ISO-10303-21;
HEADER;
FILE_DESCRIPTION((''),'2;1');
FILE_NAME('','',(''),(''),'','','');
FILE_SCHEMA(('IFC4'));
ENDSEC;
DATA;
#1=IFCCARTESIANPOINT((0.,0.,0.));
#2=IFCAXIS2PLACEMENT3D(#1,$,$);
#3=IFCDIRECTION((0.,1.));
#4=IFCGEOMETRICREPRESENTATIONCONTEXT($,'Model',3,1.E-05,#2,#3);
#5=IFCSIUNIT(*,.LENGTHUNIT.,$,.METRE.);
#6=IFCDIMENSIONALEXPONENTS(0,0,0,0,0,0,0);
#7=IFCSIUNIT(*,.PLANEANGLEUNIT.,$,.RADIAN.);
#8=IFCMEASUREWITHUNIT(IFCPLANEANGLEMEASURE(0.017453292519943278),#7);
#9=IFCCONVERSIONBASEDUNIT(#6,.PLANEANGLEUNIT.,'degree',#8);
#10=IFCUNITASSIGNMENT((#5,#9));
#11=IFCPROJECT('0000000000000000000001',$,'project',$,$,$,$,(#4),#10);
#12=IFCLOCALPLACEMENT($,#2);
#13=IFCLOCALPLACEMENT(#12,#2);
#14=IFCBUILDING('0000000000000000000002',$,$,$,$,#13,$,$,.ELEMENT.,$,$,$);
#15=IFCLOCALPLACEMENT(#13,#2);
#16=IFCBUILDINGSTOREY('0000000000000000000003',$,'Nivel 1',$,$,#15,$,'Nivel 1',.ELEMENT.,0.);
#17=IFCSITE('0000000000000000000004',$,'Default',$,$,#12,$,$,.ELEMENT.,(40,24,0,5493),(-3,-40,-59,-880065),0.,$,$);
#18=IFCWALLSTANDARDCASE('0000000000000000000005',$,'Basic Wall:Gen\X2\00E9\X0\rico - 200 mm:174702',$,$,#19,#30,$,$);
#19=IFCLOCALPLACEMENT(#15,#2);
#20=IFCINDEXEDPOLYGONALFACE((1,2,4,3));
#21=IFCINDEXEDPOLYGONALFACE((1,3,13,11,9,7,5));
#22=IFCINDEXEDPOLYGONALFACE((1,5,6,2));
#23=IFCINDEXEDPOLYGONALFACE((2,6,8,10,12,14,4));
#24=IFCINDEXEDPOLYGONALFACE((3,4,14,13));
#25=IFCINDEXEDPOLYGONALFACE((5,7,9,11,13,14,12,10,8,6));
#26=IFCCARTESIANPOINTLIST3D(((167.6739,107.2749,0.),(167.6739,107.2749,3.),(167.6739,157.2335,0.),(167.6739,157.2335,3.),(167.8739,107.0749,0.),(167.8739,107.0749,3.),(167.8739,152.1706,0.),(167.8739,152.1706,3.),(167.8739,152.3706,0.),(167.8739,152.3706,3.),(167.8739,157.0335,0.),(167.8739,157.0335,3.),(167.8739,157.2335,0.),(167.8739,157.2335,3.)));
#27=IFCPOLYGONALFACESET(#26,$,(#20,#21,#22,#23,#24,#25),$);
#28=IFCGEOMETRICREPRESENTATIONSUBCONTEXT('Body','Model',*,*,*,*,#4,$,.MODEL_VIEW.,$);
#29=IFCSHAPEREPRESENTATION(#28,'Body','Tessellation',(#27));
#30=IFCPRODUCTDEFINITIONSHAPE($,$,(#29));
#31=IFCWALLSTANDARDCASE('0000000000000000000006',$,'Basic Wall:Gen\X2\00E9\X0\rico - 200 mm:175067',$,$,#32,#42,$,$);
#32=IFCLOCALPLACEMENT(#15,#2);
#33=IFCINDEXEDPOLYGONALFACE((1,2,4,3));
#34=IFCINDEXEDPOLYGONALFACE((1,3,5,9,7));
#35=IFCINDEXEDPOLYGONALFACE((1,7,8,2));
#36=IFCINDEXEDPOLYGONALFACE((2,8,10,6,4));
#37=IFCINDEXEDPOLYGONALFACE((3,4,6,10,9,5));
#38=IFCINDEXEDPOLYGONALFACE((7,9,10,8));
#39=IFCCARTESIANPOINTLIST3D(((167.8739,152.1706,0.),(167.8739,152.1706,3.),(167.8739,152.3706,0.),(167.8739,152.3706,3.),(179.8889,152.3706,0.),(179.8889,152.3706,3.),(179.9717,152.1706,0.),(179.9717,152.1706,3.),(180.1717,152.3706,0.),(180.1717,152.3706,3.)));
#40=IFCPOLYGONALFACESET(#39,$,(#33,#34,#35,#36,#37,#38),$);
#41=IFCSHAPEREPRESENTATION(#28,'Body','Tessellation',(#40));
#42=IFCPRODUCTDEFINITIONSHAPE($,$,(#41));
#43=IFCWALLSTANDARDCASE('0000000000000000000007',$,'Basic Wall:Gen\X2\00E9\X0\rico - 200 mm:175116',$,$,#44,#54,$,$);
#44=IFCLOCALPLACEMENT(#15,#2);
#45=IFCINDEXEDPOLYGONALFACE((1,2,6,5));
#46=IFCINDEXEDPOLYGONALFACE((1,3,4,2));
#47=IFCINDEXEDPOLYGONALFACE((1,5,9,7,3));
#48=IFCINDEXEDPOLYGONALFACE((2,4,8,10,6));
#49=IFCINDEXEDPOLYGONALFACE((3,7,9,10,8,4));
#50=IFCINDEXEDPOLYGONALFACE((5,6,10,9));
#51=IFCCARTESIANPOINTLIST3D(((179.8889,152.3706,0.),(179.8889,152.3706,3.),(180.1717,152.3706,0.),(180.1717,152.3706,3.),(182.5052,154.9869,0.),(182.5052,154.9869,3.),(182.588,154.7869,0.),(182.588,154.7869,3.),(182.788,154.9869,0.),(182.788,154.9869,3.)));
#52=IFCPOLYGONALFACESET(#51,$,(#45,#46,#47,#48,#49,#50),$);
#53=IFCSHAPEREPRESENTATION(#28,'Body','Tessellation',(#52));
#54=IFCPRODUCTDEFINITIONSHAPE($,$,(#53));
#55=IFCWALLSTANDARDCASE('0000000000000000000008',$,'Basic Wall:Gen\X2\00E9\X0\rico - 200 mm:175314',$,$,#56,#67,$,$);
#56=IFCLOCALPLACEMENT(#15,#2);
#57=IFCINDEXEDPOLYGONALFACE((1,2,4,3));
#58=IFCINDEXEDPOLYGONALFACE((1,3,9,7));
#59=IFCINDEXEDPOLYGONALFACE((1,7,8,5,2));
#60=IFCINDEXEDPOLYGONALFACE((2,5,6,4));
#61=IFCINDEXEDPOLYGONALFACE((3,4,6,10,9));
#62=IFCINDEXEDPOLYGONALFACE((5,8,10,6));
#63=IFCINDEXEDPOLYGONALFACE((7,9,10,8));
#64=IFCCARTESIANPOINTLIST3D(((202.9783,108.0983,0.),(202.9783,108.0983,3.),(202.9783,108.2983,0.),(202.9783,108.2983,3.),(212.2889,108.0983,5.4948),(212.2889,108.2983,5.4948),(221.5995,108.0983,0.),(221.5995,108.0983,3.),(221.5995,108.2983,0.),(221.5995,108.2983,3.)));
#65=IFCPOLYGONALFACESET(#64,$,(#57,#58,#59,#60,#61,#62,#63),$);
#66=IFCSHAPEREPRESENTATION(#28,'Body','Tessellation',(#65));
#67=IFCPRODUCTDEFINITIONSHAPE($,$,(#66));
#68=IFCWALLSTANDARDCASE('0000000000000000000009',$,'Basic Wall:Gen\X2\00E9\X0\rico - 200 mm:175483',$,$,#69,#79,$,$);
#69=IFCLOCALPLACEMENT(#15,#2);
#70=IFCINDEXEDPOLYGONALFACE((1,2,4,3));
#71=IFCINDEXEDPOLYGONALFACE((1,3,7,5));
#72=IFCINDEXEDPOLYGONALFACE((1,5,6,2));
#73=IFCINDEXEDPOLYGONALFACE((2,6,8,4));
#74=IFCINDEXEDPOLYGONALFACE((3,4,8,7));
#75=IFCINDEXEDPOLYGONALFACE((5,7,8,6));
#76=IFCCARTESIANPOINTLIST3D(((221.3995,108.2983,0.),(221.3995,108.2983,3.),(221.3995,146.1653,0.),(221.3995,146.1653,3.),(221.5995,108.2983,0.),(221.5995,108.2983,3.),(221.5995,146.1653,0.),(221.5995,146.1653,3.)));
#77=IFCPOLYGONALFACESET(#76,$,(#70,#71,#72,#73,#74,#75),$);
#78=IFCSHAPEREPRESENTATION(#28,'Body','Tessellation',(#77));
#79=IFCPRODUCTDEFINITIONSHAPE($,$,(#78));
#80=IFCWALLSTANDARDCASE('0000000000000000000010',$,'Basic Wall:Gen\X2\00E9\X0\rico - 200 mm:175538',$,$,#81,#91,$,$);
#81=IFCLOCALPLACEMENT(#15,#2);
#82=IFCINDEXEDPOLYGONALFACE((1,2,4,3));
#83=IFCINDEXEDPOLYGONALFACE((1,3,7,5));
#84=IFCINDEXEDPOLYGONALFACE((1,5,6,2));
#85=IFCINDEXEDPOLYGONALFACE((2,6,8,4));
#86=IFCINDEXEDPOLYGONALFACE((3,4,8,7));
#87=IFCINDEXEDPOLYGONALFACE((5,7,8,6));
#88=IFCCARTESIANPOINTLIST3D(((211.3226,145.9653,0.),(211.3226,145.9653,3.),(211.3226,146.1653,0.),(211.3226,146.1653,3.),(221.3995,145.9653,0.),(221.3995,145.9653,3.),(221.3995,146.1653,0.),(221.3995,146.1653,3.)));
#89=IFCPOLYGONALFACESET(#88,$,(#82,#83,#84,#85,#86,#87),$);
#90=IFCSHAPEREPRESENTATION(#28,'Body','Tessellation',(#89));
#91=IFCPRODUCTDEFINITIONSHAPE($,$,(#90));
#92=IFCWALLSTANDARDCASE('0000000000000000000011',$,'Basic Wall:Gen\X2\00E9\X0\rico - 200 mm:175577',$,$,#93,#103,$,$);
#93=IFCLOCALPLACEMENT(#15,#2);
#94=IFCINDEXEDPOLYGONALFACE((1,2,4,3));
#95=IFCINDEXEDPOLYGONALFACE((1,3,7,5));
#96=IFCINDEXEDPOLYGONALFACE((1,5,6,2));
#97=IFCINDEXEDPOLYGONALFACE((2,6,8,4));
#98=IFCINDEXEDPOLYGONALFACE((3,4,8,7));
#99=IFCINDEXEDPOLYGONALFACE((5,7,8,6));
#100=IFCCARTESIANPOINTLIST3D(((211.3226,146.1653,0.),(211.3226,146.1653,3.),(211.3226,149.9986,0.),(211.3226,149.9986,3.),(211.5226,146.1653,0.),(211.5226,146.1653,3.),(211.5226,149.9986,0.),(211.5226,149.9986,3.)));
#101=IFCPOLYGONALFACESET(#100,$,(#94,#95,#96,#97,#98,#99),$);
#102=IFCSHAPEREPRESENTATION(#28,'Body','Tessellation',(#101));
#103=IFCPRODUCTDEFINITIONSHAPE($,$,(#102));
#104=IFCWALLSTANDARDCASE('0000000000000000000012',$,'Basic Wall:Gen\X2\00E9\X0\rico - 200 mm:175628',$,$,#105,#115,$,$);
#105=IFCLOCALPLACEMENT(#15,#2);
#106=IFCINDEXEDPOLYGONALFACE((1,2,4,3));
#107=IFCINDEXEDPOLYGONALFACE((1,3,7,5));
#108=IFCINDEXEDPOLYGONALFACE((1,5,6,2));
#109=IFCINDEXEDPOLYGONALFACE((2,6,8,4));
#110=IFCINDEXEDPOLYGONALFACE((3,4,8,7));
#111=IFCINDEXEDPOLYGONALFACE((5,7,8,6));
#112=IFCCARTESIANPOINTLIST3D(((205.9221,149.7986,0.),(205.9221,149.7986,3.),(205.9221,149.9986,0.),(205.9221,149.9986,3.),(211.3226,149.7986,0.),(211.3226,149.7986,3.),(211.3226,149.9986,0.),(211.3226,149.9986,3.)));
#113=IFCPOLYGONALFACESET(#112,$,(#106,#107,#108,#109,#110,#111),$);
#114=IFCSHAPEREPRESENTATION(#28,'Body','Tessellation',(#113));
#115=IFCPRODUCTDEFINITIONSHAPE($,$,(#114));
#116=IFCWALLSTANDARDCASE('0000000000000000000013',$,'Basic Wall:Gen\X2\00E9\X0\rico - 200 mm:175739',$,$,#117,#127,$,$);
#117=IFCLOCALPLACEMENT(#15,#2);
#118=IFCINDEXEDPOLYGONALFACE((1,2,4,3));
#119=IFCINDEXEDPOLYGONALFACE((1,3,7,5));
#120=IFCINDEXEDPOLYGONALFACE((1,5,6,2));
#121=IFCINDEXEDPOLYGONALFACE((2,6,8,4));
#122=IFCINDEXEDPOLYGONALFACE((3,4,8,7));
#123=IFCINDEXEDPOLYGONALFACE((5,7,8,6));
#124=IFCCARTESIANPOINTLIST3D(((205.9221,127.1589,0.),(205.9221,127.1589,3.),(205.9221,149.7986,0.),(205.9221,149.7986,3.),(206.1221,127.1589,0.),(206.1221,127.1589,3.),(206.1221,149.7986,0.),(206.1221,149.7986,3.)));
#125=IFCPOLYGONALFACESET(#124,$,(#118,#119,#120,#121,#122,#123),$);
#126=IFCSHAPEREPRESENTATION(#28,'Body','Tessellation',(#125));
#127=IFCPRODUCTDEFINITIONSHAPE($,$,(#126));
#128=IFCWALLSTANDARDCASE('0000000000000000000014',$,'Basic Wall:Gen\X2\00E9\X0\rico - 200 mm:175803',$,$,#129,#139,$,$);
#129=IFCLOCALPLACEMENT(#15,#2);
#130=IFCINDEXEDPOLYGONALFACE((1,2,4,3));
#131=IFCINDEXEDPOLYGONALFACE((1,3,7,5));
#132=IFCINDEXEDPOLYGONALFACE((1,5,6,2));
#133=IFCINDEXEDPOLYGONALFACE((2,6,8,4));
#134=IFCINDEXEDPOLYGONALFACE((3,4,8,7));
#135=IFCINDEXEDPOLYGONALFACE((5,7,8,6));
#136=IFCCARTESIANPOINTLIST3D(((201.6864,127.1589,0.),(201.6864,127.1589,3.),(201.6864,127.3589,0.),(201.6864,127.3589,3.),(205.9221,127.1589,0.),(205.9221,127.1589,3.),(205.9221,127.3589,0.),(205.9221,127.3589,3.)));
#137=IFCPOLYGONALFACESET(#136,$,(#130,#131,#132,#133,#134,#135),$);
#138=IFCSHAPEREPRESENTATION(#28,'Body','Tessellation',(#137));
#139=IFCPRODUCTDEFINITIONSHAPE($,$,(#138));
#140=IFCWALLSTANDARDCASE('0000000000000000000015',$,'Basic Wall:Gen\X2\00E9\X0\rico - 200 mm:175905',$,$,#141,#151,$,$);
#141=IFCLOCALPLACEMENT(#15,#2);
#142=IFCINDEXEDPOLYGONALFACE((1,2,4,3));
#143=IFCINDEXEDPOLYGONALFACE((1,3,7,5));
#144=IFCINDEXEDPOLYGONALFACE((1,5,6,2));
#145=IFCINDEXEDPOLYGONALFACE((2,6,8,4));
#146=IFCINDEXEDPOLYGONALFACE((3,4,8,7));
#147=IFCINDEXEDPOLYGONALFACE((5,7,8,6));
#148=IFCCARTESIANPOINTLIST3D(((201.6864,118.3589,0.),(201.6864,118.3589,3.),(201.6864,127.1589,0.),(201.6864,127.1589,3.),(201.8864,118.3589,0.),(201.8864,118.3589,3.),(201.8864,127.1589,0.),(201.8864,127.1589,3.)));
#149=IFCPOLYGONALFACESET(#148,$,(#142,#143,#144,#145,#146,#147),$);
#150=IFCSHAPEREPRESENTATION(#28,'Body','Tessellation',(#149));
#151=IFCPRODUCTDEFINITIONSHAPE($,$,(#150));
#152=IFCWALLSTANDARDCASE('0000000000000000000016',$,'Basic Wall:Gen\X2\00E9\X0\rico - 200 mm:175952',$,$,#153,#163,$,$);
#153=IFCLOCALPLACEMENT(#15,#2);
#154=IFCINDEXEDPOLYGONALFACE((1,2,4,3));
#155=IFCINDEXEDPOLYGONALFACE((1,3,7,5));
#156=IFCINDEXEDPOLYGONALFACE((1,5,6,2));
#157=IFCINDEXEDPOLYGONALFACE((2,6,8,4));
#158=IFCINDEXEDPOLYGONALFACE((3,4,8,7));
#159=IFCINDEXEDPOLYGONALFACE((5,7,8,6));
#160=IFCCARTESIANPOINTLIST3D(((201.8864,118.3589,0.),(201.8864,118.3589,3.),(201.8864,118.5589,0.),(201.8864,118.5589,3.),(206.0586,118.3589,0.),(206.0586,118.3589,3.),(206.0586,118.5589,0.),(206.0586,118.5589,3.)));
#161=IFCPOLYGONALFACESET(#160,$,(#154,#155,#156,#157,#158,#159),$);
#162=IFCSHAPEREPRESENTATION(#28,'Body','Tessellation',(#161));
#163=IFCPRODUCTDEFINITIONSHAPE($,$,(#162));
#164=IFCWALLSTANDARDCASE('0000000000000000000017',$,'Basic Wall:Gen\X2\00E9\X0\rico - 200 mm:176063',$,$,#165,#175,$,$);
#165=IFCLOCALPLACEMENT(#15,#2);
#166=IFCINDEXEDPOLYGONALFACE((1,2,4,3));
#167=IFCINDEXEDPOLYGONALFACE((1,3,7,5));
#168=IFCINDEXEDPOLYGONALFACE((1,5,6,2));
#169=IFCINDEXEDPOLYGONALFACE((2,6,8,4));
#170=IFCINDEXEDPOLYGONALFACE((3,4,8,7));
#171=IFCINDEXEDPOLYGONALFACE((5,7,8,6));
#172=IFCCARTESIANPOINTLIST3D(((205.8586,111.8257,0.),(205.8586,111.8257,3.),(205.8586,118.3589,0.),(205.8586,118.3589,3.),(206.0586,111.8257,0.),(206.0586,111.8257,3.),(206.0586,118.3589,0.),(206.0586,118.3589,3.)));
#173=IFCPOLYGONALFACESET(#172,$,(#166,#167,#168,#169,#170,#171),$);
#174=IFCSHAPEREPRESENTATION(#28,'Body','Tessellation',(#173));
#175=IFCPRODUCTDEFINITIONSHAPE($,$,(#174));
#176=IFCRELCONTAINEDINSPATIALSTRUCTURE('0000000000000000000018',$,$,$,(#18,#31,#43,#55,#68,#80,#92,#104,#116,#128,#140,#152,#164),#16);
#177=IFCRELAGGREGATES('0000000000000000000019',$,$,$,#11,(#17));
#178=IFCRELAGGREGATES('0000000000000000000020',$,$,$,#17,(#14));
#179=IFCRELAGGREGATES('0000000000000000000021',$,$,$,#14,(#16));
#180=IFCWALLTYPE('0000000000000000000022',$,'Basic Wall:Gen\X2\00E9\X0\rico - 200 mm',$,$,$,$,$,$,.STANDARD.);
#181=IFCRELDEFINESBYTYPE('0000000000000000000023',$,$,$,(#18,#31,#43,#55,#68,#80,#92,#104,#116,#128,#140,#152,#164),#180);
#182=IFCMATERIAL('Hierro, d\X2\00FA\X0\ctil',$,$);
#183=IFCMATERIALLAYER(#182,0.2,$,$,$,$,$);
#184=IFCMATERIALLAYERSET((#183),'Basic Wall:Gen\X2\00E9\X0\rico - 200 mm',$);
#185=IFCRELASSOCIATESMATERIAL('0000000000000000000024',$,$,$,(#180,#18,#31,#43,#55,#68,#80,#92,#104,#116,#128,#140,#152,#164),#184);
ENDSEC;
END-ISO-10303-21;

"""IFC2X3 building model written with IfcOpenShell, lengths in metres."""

from ifc_helpers import new_model, entity, si_unit, converted_unit, direction, frame, frame_2d, origin, place, context, subcontext, project, spatial, polyline, rectangle, outline, extrude, clip, bounded_halfspace, material, layer, layer_set, layer_usage, type_object, element, save


model = new_model("IFC2X3")

# Units and contexts
model_context = context("Model", 3, precision=1e-05, world=origin(), true_north=direction((0.0, 1.0)))
body_context = subcontext(model_context, "Body", "Model", "MODEL_VIEW")
ifc_project = project(units=[si_unit("LENGTHUNIT", "METRE"), converted_unit("PLANEANGLEUNIT", "degree", entity("IfcPlaneAngleMeasure", 0.017453292519943278), si_unit("PLANEANGLEUNIT", "RADIAN"), dimensions=[0, 0, 0, 0, 0, 0, 0])], contexts=[model_context])

# Site, building, storey
site_placement = place(None, origin())
site = spatial("IfcSite", under=ifc_project, at=site_placement, Name="Default", CompositionType="ELEMENT", RefLatitude=(40, 24, 0, 5493), RefLongitude=(-3, -40, -59, -880065), RefElevation=0.0)
building_placement = place(site_placement, origin())
building = spatial("IfcBuilding", under=site, at=building_placement, CompositionType="ELEMENT")
storey_placement = place(building_placement, origin())
storey = spatial("IfcBuildingStorey", under=building, at=storey_placement, Name="Nivel 1", LongName="Nivel 1", CompositionType="ELEMENT", Elevation=0.0)

# Walls
ifc_material_1 = material(Name="Hierro, dúctil")
ifc_layer_1 = layer(ifc_material_1, 0.2)
ifc_layer_set_1 = layer_set([ifc_layer_1], Name="Basic Wall:Genérico - 200 mm")
wall_type = type_object("IfcWallType", Name="Basic Wall:Genérico - 200 mm", PredefinedType="STANDARD", material=ifc_layer_set_1)
ifc_layer_usage_1 = layer_usage(ifc_layer_set_1, "AXIS2", "NEGATIVE", 0.1)
wall_1_placement = place(storey_placement, frame((167.7739, 107.0749, 0.0), z_axis=(0.0, 0.0, 1.0), x_axis=(0.0, 1.0, 0.0)))
element("IfcWallStandardCase", 1, at=wall_1_placement, inside=storey, type_object=wall_type, material=ifc_layer_usage_1, Name="Basic Wall:Genérico - 200 mm:174702", context=body_context, shape_type="SweptSolid", body=[
    extrude(outline(polyline([(50.1586, -0.1), (50.1586, 0.1), (0.2, 0.1), (0.0, -0.1), (45.0957, -0.1), (45.2957, -0.1), (49.9586, -0.1), (50.1586, -0.1)])), origin(), (0.0, 0.0, 1.0), 3.0),
])
ifc_layer_usage_2 = layer_usage(ifc_layer_set_1, "AXIS2", "NEGATIVE", 0.1)
wall_2_placement = place(storey_placement, frame((167.8739, 152.2706, 0.0)))
element("IfcWallStandardCase", 2, at=wall_2_placement, inside=storey, type_object=wall_type, material=ifc_layer_usage_2, Name="Basic Wall:Genérico - 200 mm:175067", context=body_context, shape_type="SweptSolid", body=[
    extrude(outline(polyline([(12.0978, -0.1), (12.2978, 0.1), (12.015, 0.1), (0.0, 0.1), (0.0, -0.1), (12.0978, -0.1)])), origin(), (0.0, 0.0, 1.0), 3.0),
])
ifc_layer_usage_3 = layer_usage(ifc_layer_set_1, "AXIS2", "NEGATIVE", 0.1)
wall_3_placement = place(storey_placement, frame((179.9596, 152.2999, 0.0), z_axis=(0.0, 0.0, 1.0), x_axis=(0.707107, 0.707107, 0.0)))
element("IfcWallStandardCase", 3, at=wall_3_placement, inside=storey, type_object=wall_type, material=ifc_layer_usage_3, Name="Basic Wall:Genérico - 200 mm:175116", context=body_context, shape_type="SweptSolid", body=[
    extrude(outline(polyline([(3.9, -0.1), (3.7, 0.1), (0.0, 0.1), (0.2, -0.1), (3.6172, -0.1), (3.9, -0.1)])), origin(), (0.0, 0.0, 1.0), 3.0),
])
ifc_layer_usage_4 = layer_usage(ifc_layer_set_1, "AXIS2", "NEGATIVE", 0.1)
wall_4_placement = place(storey_placement, frame((202.9783, 108.1983, 0.0)))
element("IfcWallStandardCase", 4, at=wall_4_placement, inside=storey, type_object=wall_type, material=ifc_layer_usage_4, Name="Basic Wall:Genérico - 200 mm:175314", context=body_context, shape_type="Clipping", body=[
    clip(clip(extrude(rectangle(XDim=18.6212, YDim=0.2, at=frame_2d((9.3106, 0.0), x_axis=(-1.0, 0.0))), origin(), (0.0, 0.0, 1.0), 5.4948), bounded_halfspace(frame((0.0, -0.1, 3.0), z_axis=(-0.258819, 0.0, 0.965926), x_axis=(0.0, -1.0, 0.0)), False, frame((0.0, -0.1, 3.0)), polyline([(0.0, 0.0), (9.3106, 0.0), (9.3106, 0.2), (0.0, 0.2), (0.0, 0.0)]))), bounded_halfspace(frame((9.3106, -0.1, 5.4948), z_axis=(0.258819, 0.0, 0.965926), x_axis=(0.0, 1.0, 0.0)), False, frame((9.3106, -0.1, 5.4948)), polyline([(0.0, 0.0), (9.3106, 0.0), (9.3106, 0.2), (0.0, 0.2), (0.0, 0.0)]))),
])
ifc_layer_usage_5 = layer_usage(ifc_layer_set_1, "AXIS2", "NEGATIVE", 0.1)
wall_5_placement = place(storey_placement, frame((221.4995, 108.2983, 0.0), z_axis=(0.0, 0.0, 1.0), x_axis=(0.0, 1.0, 0.0)))
element("IfcWallStandardCase", 5, at=wall_5_placement, inside=storey, type_object=wall_type, material=ifc_layer_usage_5, Name="Basic Wall:Genérico - 200 mm:175483", context=body_context, shape_type="SweptSolid", body=[
    extrude(rectangle(XDim=37.867, YDim=0.2, at=frame_2d((18.9335, 0.0), x_axis=(-1.0, 0.0))), origin(), (0.0, 0.0, 1.0), 3.0),
])
ifc_layer_usage_6 = layer_usage(ifc_layer_set_1, "AXIS2", "NEGATIVE", 0.1)
wall_6_placement = place(storey_placement, frame((221.3995, 146.0653, 0.0), z_axis=(0.0, 0.0, 1.0), x_axis=(-1.0, 0.0, 0.0)))
element("IfcWallStandardCase", 6, at=wall_6_placement, inside=storey, type_object=wall_type, material=ifc_layer_usage_6, Name="Basic Wall:Genérico - 200 mm:175538", context=body_context, shape_type="SweptSolid", body=[
    extrude(rectangle(XDim=10.0769, YDim=0.2, at=frame_2d((5.0384, 0.0), x_axis=(-1.0, 0.0))), origin(), (0.0, 0.0, 1.0), 3.0),
])
ifc_layer_usage_7 = layer_usage(ifc_layer_set_1, "AXIS2", "NEGATIVE", 0.1)
wall_7_placement = place(storey_placement, frame((211.4226, 146.1653, 0.0), z_axis=(0.0, 0.0, 1.0), x_axis=(0.0, 1.0, 0.0)))
element("IfcWallStandardCase", 7, at=wall_7_placement, inside=storey, type_object=wall_type, material=ifc_layer_usage_7, Name="Basic Wall:Genérico - 200 mm:175577", context=body_context, shape_type="SweptSolid", body=[
    extrude(rectangle(XDim=3.8333, YDim=0.2, at=frame_2d((1.9166, 0.0), x_axis=(-1.0, 0.0))), origin(), (0.0, 0.0, 1.0), 3.0),
])
ifc_layer_usage_8 = layer_usage(ifc_layer_set_1, "AXIS2", "NEGATIVE", 0.1)
wall_8_placement = place(storey_placement, frame((211.3226, 149.8986, 0.0), z_axis=(0.0, 0.0, 1.0), x_axis=(-1.0, 0.0, 0.0)))
element("IfcWallStandardCase", 8, at=wall_8_placement, inside=storey, type_object=wall_type, material=ifc_layer_usage_8, Name="Basic Wall:Genérico - 200 mm:175628", context=body_context, shape_type="SweptSolid", body=[
    extrude(rectangle(XDim=5.4005, YDim=0.2, at=frame_2d((2.7002, 0.0), x_axis=(-1.0, 0.0))), origin(), (0.0, 0.0, 1.0), 3.0),
])
ifc_layer_usage_9 = layer_usage(ifc_layer_set_1, "AXIS2", "NEGATIVE", 0.1)
wall_9_placement = place(storey_placement, frame((206.0221, 149.7986, 0.0), z_axis=(0.0, 0.0, 1.0), x_axis=(0.0, -1.0, 0.0)))
element("IfcWallStandardCase", 9, at=wall_9_placement, inside=storey, type_object=wall_type, material=ifc_layer_usage_9, Name="Basic Wall:Genérico - 200 mm:175739", context=body_context, shape_type="SweptSolid", body=[
    extrude(rectangle(XDim=22.6397, YDim=0.2, at=frame_2d((11.3199, 0.0), x_axis=(-1.0, 0.0))), origin(), (0.0, 0.0, 1.0), 3.0),
])
ifc_layer_usage_10 = layer_usage(ifc_layer_set_1, "AXIS2", "NEGATIVE", 0.1)
wall_10_placement = place(storey_placement, frame((205.9221, 127.2589, 0.0), z_axis=(0.0, 0.0, 1.0), x_axis=(-1.0, 0.0, 0.0)))
element("IfcWallStandardCase", 10, at=wall_10_placement, inside=storey, type_object=wall_type, material=ifc_layer_usage_10, Name="Basic Wall:Genérico - 200 mm:175803", context=body_context, shape_type="SweptSolid", body=[
    extrude(rectangle(XDim=4.2357, YDim=0.2, at=frame_2d((2.1178, 0.0), x_axis=(-1.0, 0.0))), origin(), (0.0, 0.0, 1.0), 3.0),
])
ifc_layer_usage_11 = layer_usage(ifc_layer_set_1, "AXIS2", "NEGATIVE", 0.1)
wall_11_placement = place(storey_placement, frame((201.7864, 127.1589, 0.0), z_axis=(0.0, 0.0, 1.0), x_axis=(0.0, -1.0, 0.0)))
element("IfcWallStandardCase", 11, at=wall_11_placement, inside=storey, type_object=wall_type, material=ifc_layer_usage_11, Name="Basic Wall:Genérico - 200 mm:175905", context=body_context, shape_type="SweptSolid", body=[
    extrude(rectangle(XDim=8.8, YDim=0.2, at=frame_2d((4.4, 0.0), x_axis=(-1.0, 0.0))), origin(), (0.0, 0.0, 1.0), 3.0),
])
ifc_layer_usage_12 = layer_usage(ifc_layer_set_1, "AXIS2", "NEGATIVE", 0.1)
wall_12_placement = place(storey_placement, frame((201.8864, 118.4589, 0.0)))
element("IfcWallStandardCase", 12, at=wall_12_placement, inside=storey, type_object=wall_type, material=ifc_layer_usage_12, Name="Basic Wall:Genérico - 200 mm:175952", context=body_context, shape_type="SweptSolid", body=[
    extrude(rectangle(XDim=4.1721, YDim=0.2, at=frame_2d((2.0861, 0.0), x_axis=(-1.0, 0.0))), origin(), (0.0, 0.0, 1.0), 3.0),
])
ifc_layer_usage_13 = layer_usage(ifc_layer_set_1, "AXIS2", "NEGATIVE", 0.1)
wall_13_placement = place(storey_placement, frame((205.9586, 118.3589, 0.0), z_axis=(0.0, 0.0, 1.0), x_axis=(0.0, -1.0, 0.0)))
element("IfcWallStandardCase", 13, at=wall_13_placement, inside=storey, type_object=wall_type, material=ifc_layer_usage_13, Name="Basic Wall:Genérico - 200 mm:176063", context=body_context, shape_type="SweptSolid", body=[
    extrude(rectangle(XDim=6.5332, YDim=0.2, at=frame_2d((3.2666, 0.0), x_axis=(-1.0, 0.0))), origin(), (0.0, 0.0, 1.0), 3.0),
])

save(model, "model.ifc")
